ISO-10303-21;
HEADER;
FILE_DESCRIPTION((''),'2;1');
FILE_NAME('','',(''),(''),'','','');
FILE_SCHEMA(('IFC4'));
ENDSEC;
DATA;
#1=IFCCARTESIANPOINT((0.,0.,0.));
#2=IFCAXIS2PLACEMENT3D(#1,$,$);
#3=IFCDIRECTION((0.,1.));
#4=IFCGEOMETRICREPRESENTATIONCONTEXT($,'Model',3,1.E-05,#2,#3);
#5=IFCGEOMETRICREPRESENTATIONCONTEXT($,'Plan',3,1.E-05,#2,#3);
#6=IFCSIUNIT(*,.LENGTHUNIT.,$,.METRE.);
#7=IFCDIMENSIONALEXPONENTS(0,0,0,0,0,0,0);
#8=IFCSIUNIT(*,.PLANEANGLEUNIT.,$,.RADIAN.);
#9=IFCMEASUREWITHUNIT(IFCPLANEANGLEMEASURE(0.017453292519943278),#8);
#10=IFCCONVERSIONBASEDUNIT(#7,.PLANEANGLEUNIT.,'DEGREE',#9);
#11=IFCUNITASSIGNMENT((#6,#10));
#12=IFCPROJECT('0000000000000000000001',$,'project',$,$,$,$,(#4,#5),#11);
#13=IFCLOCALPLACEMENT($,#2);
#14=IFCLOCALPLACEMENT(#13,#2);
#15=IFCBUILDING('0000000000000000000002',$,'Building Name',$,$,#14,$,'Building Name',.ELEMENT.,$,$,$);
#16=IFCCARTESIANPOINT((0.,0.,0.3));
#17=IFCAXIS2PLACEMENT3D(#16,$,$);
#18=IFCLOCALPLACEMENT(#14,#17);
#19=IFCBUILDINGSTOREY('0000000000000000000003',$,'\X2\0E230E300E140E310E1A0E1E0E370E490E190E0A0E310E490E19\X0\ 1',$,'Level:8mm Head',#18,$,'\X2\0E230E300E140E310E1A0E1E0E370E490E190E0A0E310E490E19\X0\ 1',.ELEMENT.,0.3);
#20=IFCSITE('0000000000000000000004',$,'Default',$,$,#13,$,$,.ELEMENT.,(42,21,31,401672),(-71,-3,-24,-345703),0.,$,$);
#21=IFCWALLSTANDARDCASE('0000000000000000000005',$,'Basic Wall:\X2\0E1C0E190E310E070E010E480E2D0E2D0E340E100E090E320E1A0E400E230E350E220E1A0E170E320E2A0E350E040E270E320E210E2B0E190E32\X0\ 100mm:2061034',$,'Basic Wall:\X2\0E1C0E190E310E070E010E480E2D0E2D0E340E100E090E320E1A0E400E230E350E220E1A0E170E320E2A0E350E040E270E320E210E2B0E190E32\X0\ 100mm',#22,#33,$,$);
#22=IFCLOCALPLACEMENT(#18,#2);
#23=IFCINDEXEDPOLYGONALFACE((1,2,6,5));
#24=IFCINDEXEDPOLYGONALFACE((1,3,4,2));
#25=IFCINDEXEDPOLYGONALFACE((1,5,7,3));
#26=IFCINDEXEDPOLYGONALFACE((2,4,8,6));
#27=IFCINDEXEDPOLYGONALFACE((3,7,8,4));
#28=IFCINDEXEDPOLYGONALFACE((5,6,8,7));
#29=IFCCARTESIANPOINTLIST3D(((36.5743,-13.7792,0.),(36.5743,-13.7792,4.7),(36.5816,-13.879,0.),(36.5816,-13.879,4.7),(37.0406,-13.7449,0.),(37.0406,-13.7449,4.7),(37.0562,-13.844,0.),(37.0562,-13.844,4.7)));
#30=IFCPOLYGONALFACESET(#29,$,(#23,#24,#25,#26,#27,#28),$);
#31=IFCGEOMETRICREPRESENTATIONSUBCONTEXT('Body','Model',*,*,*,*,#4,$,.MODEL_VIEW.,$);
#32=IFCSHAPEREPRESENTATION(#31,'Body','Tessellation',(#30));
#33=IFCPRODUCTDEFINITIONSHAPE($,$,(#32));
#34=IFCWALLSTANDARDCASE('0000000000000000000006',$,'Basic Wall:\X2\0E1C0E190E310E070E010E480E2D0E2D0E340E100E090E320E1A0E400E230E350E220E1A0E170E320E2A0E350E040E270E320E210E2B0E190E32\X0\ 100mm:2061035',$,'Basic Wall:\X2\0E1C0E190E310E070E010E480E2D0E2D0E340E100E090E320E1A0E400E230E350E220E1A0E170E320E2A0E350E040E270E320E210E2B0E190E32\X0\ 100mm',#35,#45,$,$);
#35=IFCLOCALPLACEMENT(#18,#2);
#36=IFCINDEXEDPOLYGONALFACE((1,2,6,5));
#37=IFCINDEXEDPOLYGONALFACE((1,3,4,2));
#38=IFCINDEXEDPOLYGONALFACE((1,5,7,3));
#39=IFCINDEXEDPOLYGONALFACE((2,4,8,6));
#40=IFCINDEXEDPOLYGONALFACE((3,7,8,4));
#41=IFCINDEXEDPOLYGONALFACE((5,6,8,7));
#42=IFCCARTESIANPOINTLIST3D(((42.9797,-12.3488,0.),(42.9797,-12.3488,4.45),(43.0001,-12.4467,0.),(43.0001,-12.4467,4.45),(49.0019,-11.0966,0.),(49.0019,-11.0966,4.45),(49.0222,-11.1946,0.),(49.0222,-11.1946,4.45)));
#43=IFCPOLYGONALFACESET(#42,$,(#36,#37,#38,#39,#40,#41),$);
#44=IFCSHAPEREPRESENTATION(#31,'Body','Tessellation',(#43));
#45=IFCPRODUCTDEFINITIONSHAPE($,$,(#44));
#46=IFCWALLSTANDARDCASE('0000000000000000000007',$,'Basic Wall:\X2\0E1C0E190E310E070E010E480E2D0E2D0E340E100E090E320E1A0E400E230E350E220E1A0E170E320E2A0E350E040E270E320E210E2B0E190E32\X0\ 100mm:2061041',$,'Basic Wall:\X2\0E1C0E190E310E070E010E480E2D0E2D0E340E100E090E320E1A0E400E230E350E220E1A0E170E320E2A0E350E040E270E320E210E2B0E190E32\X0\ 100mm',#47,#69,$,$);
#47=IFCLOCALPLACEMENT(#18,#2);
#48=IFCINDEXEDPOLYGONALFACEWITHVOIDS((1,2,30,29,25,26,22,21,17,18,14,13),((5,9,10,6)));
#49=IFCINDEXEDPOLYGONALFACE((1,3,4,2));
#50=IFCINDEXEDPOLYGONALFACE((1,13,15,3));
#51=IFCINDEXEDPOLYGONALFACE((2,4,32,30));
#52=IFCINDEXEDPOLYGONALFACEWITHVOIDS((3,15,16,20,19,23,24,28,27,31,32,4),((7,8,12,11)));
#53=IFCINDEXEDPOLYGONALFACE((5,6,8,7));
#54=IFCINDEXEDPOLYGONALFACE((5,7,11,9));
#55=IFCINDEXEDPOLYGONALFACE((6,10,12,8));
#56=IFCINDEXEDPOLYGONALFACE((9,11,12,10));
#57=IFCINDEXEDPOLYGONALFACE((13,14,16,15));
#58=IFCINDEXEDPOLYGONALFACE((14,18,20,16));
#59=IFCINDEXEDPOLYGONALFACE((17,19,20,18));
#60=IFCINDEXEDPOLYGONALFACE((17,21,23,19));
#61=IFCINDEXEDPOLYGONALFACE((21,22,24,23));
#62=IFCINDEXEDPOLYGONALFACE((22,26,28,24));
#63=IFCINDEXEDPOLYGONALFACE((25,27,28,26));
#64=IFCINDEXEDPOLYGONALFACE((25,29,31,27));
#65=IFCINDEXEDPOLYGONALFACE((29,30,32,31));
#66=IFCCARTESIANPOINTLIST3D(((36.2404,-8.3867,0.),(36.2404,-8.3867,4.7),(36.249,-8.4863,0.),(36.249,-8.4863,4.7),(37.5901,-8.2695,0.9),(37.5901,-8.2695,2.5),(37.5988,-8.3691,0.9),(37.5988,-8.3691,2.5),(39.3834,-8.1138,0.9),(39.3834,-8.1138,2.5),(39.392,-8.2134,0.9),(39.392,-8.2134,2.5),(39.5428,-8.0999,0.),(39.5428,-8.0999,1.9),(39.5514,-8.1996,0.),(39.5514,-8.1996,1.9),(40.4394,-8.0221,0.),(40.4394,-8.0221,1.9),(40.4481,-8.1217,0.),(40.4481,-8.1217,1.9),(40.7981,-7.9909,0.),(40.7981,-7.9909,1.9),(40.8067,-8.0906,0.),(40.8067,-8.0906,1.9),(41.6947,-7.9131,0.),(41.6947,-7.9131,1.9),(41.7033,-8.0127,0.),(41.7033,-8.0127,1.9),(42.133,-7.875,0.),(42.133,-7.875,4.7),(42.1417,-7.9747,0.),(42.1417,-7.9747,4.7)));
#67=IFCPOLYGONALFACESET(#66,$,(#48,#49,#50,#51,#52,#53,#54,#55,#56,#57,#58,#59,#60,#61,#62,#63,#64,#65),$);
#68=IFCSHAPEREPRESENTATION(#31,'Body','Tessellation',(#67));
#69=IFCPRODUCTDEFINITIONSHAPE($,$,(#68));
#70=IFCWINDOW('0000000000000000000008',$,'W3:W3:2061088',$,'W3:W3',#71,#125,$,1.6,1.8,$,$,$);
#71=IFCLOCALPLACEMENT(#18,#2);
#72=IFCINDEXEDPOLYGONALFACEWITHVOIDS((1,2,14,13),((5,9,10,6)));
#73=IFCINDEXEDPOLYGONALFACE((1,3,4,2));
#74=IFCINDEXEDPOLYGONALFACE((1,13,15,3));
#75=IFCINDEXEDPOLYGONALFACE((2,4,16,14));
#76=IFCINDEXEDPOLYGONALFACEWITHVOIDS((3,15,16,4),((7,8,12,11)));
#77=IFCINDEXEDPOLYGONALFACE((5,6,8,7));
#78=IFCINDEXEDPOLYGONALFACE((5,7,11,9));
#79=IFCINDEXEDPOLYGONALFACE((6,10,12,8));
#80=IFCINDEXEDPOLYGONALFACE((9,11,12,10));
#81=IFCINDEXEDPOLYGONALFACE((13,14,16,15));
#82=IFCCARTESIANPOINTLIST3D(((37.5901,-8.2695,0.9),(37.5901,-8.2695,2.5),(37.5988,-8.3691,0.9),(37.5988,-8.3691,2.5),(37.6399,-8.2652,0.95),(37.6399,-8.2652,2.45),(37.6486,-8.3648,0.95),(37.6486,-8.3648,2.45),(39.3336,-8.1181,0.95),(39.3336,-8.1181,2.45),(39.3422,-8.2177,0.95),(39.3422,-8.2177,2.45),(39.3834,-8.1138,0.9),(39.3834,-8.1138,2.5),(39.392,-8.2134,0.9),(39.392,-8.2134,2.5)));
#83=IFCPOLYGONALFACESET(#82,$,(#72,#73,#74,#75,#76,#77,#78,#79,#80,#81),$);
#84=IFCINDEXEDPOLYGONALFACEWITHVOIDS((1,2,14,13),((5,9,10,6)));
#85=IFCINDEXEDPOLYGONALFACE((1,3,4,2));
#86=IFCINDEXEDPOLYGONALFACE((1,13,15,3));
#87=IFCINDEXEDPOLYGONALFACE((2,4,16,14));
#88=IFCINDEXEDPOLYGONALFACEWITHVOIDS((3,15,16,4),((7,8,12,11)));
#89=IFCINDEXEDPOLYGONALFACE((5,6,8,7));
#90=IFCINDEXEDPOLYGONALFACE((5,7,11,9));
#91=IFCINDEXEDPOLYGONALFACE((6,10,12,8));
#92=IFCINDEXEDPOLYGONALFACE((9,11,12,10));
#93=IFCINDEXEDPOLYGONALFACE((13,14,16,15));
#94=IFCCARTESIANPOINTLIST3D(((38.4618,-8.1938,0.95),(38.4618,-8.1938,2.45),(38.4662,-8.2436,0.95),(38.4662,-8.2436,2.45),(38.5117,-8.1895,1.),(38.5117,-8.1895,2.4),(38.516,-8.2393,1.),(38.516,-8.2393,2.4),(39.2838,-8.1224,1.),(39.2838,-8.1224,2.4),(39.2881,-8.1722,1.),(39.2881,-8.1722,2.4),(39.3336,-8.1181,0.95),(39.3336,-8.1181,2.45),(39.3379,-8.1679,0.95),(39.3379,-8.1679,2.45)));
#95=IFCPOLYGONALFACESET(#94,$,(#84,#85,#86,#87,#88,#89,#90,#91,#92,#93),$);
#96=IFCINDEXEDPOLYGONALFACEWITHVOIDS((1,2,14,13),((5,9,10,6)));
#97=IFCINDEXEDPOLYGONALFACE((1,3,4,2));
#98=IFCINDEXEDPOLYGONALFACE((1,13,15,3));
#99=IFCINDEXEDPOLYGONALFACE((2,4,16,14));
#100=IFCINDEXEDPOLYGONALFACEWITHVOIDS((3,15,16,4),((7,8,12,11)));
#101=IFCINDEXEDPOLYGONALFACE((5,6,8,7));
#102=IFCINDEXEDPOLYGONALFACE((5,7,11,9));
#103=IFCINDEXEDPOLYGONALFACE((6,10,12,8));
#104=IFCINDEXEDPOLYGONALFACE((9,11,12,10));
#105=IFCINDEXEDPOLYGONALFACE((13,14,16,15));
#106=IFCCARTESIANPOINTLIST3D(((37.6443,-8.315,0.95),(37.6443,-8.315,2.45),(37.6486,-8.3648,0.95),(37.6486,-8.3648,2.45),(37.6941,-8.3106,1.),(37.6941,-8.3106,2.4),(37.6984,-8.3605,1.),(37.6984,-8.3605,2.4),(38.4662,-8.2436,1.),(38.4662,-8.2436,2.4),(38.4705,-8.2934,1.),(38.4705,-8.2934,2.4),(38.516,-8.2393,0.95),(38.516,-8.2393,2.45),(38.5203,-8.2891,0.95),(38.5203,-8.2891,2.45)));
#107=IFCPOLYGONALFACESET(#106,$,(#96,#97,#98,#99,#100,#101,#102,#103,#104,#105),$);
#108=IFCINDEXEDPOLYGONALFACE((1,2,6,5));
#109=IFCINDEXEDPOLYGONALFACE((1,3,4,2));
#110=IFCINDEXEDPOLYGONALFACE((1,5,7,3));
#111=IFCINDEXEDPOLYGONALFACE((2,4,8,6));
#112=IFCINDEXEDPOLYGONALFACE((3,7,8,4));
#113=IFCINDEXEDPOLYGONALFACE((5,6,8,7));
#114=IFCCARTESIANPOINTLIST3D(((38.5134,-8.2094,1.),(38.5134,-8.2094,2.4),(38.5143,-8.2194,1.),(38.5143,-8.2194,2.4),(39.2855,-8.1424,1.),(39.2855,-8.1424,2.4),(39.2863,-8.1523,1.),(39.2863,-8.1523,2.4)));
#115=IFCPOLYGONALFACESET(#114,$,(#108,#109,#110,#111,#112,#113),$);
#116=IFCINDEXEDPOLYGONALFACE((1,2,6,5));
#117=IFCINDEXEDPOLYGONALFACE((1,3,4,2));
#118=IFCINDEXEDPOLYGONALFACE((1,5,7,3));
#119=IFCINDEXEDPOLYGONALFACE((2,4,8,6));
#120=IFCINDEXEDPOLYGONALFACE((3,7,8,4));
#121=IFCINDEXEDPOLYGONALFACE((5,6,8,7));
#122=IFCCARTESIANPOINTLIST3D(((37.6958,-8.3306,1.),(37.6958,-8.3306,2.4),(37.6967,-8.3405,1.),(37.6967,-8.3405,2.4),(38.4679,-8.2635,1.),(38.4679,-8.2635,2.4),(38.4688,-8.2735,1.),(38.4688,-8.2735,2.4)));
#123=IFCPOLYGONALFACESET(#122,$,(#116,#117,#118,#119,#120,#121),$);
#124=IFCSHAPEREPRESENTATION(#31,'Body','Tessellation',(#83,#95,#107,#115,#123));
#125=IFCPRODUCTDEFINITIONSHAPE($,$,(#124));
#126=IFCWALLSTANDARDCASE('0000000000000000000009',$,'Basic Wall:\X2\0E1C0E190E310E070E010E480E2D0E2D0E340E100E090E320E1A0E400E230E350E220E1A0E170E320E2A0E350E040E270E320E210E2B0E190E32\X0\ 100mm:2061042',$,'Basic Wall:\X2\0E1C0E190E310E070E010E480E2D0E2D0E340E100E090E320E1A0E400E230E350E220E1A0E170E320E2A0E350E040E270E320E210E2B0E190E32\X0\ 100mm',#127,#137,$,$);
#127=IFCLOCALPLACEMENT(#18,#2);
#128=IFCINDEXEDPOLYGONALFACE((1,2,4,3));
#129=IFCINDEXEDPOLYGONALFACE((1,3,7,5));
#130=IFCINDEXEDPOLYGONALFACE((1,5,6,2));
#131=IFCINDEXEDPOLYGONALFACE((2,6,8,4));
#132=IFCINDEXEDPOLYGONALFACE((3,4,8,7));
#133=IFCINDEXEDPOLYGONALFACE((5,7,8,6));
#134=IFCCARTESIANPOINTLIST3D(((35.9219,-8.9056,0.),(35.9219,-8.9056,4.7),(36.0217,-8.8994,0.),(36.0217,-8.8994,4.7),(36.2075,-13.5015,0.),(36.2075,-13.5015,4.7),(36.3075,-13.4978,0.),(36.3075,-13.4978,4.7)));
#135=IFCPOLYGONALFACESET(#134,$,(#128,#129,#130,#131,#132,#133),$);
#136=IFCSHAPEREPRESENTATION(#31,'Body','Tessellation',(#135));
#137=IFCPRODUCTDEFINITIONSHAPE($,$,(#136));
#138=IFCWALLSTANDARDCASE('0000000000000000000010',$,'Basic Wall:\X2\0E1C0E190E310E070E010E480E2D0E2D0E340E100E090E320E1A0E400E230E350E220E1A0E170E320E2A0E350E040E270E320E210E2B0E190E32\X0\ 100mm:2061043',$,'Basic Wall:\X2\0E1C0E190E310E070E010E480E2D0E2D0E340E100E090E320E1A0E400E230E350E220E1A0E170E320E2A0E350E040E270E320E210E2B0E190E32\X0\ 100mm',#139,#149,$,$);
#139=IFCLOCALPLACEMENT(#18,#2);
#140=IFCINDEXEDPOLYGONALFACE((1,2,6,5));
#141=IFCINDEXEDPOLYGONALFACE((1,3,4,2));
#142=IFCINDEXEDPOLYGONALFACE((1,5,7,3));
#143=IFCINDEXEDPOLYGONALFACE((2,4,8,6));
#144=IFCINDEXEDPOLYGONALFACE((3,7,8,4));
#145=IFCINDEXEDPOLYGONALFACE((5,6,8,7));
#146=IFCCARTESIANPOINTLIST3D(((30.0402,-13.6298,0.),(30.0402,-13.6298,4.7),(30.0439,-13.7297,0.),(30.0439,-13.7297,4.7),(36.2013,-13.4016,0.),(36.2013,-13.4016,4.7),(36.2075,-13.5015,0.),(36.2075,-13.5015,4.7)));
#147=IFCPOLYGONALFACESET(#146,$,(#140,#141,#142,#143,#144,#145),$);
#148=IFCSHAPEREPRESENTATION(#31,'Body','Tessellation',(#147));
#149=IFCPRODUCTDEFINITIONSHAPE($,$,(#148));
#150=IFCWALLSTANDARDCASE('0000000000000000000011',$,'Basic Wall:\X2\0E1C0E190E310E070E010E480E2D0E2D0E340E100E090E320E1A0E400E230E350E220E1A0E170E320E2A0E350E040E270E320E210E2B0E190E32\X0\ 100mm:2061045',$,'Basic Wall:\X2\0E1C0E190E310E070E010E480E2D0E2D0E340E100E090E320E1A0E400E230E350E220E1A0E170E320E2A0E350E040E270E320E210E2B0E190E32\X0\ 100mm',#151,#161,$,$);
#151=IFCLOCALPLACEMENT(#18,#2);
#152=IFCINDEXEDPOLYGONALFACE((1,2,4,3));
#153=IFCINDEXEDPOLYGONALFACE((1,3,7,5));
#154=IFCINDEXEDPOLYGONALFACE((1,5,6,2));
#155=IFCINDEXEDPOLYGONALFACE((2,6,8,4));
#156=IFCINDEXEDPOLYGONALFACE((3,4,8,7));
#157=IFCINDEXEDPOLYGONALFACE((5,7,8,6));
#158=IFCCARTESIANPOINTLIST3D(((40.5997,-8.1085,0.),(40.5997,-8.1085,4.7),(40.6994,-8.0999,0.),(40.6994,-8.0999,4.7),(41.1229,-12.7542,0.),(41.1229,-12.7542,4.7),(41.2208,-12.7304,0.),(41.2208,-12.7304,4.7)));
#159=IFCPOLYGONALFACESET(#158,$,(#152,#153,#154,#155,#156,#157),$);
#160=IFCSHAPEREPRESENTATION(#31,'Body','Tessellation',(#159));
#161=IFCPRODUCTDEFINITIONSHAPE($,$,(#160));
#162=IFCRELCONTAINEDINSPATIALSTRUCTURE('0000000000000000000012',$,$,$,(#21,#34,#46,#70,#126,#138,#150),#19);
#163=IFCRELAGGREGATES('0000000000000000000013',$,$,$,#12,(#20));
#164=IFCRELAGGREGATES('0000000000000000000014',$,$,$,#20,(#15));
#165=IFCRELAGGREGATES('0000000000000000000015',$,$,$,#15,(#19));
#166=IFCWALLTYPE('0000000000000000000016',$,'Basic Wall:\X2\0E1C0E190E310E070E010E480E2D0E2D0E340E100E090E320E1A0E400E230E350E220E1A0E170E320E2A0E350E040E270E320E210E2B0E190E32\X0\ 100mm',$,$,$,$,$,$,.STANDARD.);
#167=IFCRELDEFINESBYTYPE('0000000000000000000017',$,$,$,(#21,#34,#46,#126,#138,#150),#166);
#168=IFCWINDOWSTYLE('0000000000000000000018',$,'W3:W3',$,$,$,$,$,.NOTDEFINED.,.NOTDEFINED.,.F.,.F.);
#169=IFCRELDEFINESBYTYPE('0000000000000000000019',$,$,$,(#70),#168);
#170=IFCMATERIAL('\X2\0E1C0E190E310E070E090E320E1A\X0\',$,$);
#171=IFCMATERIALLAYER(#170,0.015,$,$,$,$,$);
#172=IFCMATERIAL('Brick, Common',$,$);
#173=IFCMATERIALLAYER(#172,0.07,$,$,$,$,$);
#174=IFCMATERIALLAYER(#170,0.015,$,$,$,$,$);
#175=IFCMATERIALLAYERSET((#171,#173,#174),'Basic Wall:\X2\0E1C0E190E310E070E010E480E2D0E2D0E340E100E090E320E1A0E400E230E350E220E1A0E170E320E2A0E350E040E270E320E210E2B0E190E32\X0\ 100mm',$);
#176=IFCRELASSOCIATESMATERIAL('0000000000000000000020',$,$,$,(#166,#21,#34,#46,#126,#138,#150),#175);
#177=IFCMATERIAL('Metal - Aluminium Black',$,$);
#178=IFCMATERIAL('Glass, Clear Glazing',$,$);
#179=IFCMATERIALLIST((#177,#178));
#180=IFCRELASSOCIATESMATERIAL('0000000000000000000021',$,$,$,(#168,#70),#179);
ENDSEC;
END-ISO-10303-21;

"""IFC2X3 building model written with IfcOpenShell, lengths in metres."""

from ifc_helpers import new_model, entity, si_unit, converted_unit, direction, frame, frame_2d, origin, place, context, subcontext, project, spatial, polyline, rectangle, outline, extrude, clip, halfspace, source, transform, mapped, material, material_list, layer, layer_set, layer_usage, type_object, type_shapes, element, fill, save


model = new_model("IFC2X3")

# Units and contexts
model_context = context("Model", 3, precision=1e-05, world=origin(), true_north=direction((0.0, 1.0)))
plan_context = context("Plan", 3, precision=1e-05, world=origin(), true_north=direction((0.0, 1.0)))
body_context = subcontext(model_context, "Body", "Model", "MODEL_VIEW")
ifc_project = project(units=[si_unit("LENGTHUNIT", "METRE"), converted_unit("PLANEANGLEUNIT", "DEGREE", entity("IfcPlaneAngleMeasure", 0.017453292519943278), si_unit("PLANEANGLEUNIT", "RADIAN"), dimensions=[0, 0, 0, 0, 0, 0, 0])], contexts=[model_context, plan_context])

# Site, building, storey
site_placement = place(None, origin())
site = spatial("IfcSite", under=ifc_project, at=site_placement, Name="Default", CompositionType="ELEMENT", RefLatitude=(42, 21, 31, 401672), RefLongitude=(-71, -3, -24, -345703), RefElevation=0.0)
building_placement = place(site_placement, origin())
building = spatial("IfcBuilding", under=site, at=building_placement, Name="Building Name", LongName="Building Name", CompositionType="ELEMENT")
storey_placement = place(building_placement, frame((0.0, 0.0, 0.3)))
storey = spatial("IfcBuildingStorey", under=building, at=storey_placement, Name="ระดับพื้นชั้น 1", ObjectType="Level:8mm Head", LongName="ระดับพื้นชั้น 1", CompositionType="ELEMENT", Elevation=0.3)

# Shared definitions
ifc_material_1 = material(Name="Glass, Clear Glazing")

# Shared definitions
ifc_material_2 = material(Name="ผนังฉาบ")
ifc_layer_1 = layer(ifc_material_2, 0.015)
ifc_material_3 = material(Name="Brick, Common")
ifc_layer_2 = layer(ifc_material_3, 0.07)
ifc_layer_3 = layer(ifc_material_2, 0.015)
ifc_layer_set = layer_set([ifc_layer_1, ifc_layer_2, ifc_layer_3], Name="Basic Wall:ผนังก่ออิฐฉาบเรียบทาสีความหนา 100mm")
wall_type = type_object("IfcWallType", Name="Basic Wall:ผนังก่ออิฐฉาบเรียบทาสีความหนา 100mm", PredefinedType="STANDARD", material=ifc_layer_set)

# Shared definitions
ifc_material_4 = material(Name="Metal - Aluminium Black")
ifc_material_list_1 = material_list([ifc_material_4, ifc_material_1])
window_style = type_object("IfcWindowStyle", Name="W3:W3", ConstructionType="NOTDEFINED", OperationType="NOTDEFINED", ParameterTakesPrecedence=False, Sizeable=False, material=ifc_material_list_1)
shared_shape_1 = source(origin(), body_context, "Body", "SweptSolid", [
    extrude(outline(polyline([(-0.8, -0.9), (0.8, -0.9), (0.8, 0.9), (-0.8, 0.9), (-0.8, -0.9)]), holes=[polyline([(0.75, -0.85), (-0.75, -0.85), (-0.75, 0.85), (0.75, 0.85), (0.75, -0.85)])]), frame((0.9, 0.0, 0.8), z_axis=(0.0, 1.0, 0.0), x_axis=(0.0, 0.0, 1.0)), (0.0, 0.0, 1.0), 0.1),
    extrude(outline(polyline([(-0.75, -0.4375), (0.75, -0.4375), (0.75, 0.4375), (-0.75, 0.4375), (-0.75, -0.4375)]), holes=[polyline([(0.7, -0.3875), (-0.7, -0.3875), (-0.7, 0.3875), (0.7, 0.3875), (0.7, -0.3875)])]), frame((1.3125, 0.05, 0.8), z_axis=(0.0, 1.0, 0.0), x_axis=(0.0, 0.0, -1.0)), (0.0, 0.0, 1.0), 0.05),
    extrude(outline(polyline([(-0.75, -0.4375), (0.75, -0.4375), (0.75, 0.4375), (-0.75, 0.4375), (-0.75, -0.4375)]), holes=[polyline([(0.7, -0.3875), (-0.7, -0.3875), (-0.7, 0.3875), (0.7, 0.3875), (0.7, -0.3875)])]), frame((0.4875, 0.0, 0.8), z_axis=(0.0, 1.0, 0.0), x_axis=(0.0, 0.0, -1.0)), (0.0, 0.0, 1.0), 0.05),
    extrude(rectangle(XDim=0.01, YDim=0.775, at=frame_2d((0.0, 0.0), x_axis=(1.0, 0.0))), frame((1.3125, 0.075, 0.1), z_axis=(0.0, 0.0, 1.0), x_axis=(0.0, -1.0, 0.0)), (0.0, 0.0, 1.0), 1.4),
    extrude(rectangle(XDim=0.01, YDim=0.775, at=frame_2d((0.0, 0.0), x_axis=(1.0, 0.0))), frame((0.4875, 0.025, 0.1), z_axis=(0.0, 0.0, 1.0), x_axis=(0.0, -1.0, 0.0)), (0.0, 0.0, 1.0), 1.4),
])
type_shapes(window_style, [shared_shape_1])

# Walls
ifc_layer_usage_1 = layer_usage(ifc_layer_set, "AXIS2", "POSITIVE", -0.05)
wall_1_placement = place(storey_placement, frame((36.578, -13.8291, 0.0), z_axis=(0.0, 0.0, 1.0), x_axis=(0.997301, 0.073417, 0.0)))
element("IfcWallStandardCase", 1, at=wall_1_placement, inside=storey, type_object=wall_type, material=ifc_layer_usage_1, Name="Basic Wall:ผนังก่ออิฐฉาบเรียบทาสีความหนา 100mm:2061034", ObjectType="Basic Wall:ผนังก่ออิฐฉาบเรียบทาสีความหนา 100mm", context=body_context, shape_type="Clipping", body=[
    clip(extrude(outline(polyline([(0.4759, -0.05), (0.4676, 0.05), (0.0, 0.05), (0.0, -0.05), (0.3646, -0.05), (0.4759, -0.05)])), origin(), (0.0, 0.0, 1.0), 4.7), halfspace(frame((0.0, 0.0, -0.15)), True)),
])
ifc_layer_usage_2 = layer_usage(ifc_layer_set, "AXIS2", "POSITIVE", -0.05)
wall_2_placement = place(storey_placement, frame((42.9899, -12.3978, 0.0), z_axis=(0.0, 0.0, 1.0), x_axis=(0.97906, 0.203573, 0.0)))
element("IfcWallStandardCase", 2, at=wall_2_placement, inside=storey, type_object=wall_type, material=ifc_layer_usage_2, Name="Basic Wall:ผนังก่ออิฐฉาบเรียบทาสีความหนา 100mm:2061035", ObjectType="Basic Wall:ผนังก่ออิฐฉาบเรียบทาสีความหนา 100mm", context=body_context, shape_type="Clipping", body=[
    clip(extrude(rectangle(XDim=6.151, YDim=0.1, at=frame_2d((3.0755, 0.0), x_axis=(-1.0, 0.0))), origin(), (0.0, 0.0, 1.0), 4.45), halfspace(frame((0.0, 0.0, -0.15)), True)),
])

# Wall, openings, window
ifc_layer_usage_3 = layer_usage(ifc_layer_set, "AXIS2", "POSITIVE", -0.05)
wall_3_placement = place(storey_placement, frame((42.1374, -7.9248, 0.0), z_axis=(0.0, 0.0, 1.0), x_axis=(-0.996252, -0.086502, 0.0)))
wall_3 = element("IfcWallStandardCase", 3, at=wall_3_placement, inside=storey, type_object=wall_type, material=ifc_layer_usage_3, Name="Basic Wall:ผนังก่ออิฐฉาบเรียบทาสีความหนา 100mm:2061041", ObjectType="Basic Wall:ผนังก่ออิฐฉาบเรียบทาสีความหนา 100mm", context=body_context, shape_type="Clipping", body=[
    clip(extrude(rectangle(XDim=5.9148, YDim=0.1, at=frame_2d((2.9574, 0.0), x_axis=(1.0, 0.0))), origin(), (0.0, 0.0, 1.0), 4.7), halfspace(frame((0.0, 0.0, -0.15)), True)),
])
opening_1_placement = place(wall_3_placement, frame((41.2939, -11.5401, -0.15), z_axis=(0.0, 0.0, 1.0), x_axis=(-0.996252, 0.086502, 0.0)))
element("IfcOpeningElement", 4, at=opening_1_placement, cuts=wall_3, ObjectType="Opening", context=body_context, shape_type="SweptSolid", body=[
    extrude(rectangle(XDim=2.05, YDim=0.9, at=frame_2d((0.0, 0.0), x_axis=(1.0, 0.0))), frame((41.1145, -6.4337, 1.025), z_axis=(0.086502, -0.996252, 0.0), x_axis=(0.0, 0.0, 1.0)), (0.0, 0.0, 1.0), 3.048),
])
opening_2_placement = place(wall_3_placement, frame((41.2939, -11.5401, -0.15), z_axis=(0.0, 0.0, 1.0), x_axis=(-0.996252, 0.086502, 0.0)))
element("IfcOpeningElement", 5, at=opening_2_placement, cuts=wall_3, ObjectType="Opening", context=body_context, shape_type="SweptSolid", body=[
    extrude(rectangle(XDim=2.05, YDim=0.9, at=frame_2d((0.0, 0.0), x_axis=(0.0, 1.0))), frame((39.8593, -6.5427, 1.025), z_axis=(0.086502, -0.996252, 0.0), x_axis=(0.996252, 0.086502, 0.0)), (0.0, 0.0, 1.0), 3.048),
])
opening_3_placement = place(wall_3_placement, frame((4.56, 0.05, 0.9)))
opening_3 = element("IfcOpeningElement", 6, at=opening_3_placement, cuts=wall_3, ObjectType="Opening", context=body_context, shape_type="SweptSolid", body=[
    extrude(rectangle(XDim=1.6, YDim=1.8, at=frame_2d((0.8, 0.9), x_axis=(1.0, 0.0))), frame((0.0, 0.0, 0.0), z_axis=(0.0, -1.0, 0.0), x_axis=(0.0, 0.0, 1.0)), (0.0, 0.0, 1.0), 0.1),
])
window_1_placement = place(opening_3_placement, frame((0.0, 0.0, 0.0), z_axis=(0.0, 0.0, 1.0), x_axis=(-1.0, 0.0, 0.0)))
window_1 = element("IfcWindow", 7, at=window_1_placement, inside=storey, type_object=window_style, material=ifc_material_list_1, Name="W3:W3:2061088", ObjectType="W3:W3", OverallHeight=1.6, OverallWidth=1.8, context=body_context, shape_type="MappedRepresentation", body=[
    mapped(shared_shape_1, transform((0.0, 0.0, 0.0), scale=1.0)),
])
fill(opening_3, window_1)

# Walls
ifc_layer_usage_4 = layer_usage(ifc_layer_set, "AXIS2", "POSITIVE", -0.05)
wall_4_placement = place(storey_placement, frame((35.9718, -8.9025, 0.0), z_axis=(0.0, 0.0, 1.0), x_axis=(0.062014, -0.998075, 0.0)))
element("IfcWallStandardCase", 8, at=wall_4_placement, inside=storey, type_object=wall_type, material=ifc_layer_usage_4, Name="Basic Wall:ผนังก่ออิฐฉาบเรียบทาสีความหนา 100mm:2061042", ObjectType="Basic Wall:ผนังก่ออิฐฉาบเรียบทาสีความหนา 100mm", context=body_context, shape_type="Clipping", body=[
    clip(extrude(outline(polyline([(4.6047, -0.05), (4.6072, 0.05), (0.0, 0.05), (0.0, -0.05), (4.5047, -0.05), (4.6047, -0.05)])), origin(), (0.0, 0.0, 1.0), 4.7), halfspace(frame((0.0, 0.0, -0.15)), True)),
])
ifc_layer_usage_5 = layer_usage(ifc_layer_set, "AXIS2", "POSITIVE", -0.05)
wall_5_placement = place(storey_placement, frame((36.2056, -13.4515, 0.0), z_axis=(0.0, 0.0, 1.0), x_axis=(-0.999315, -0.037003, 0.0)))
element("IfcWallStandardCase", 9, at=wall_5_placement, inside=storey, type_object=wall_type, material=ifc_layer_usage_5, Name="Basic Wall:ผนังก่ออิฐฉาบเรียบทาสีความหนา 100mm:2061043", ObjectType="Basic Wall:ผนังก่ออิฐฉาบเรียบทาสีความหนา 100mm", context=body_context, shape_type="Clipping", body=[
    clip(extrude(outline(polyline([(6.1678, -0.05), (6.1678, 0.05), (0.0, 0.05), (0.0025, -0.05), (6.1678, -0.05)])), origin(), (0.0, 0.0, 1.0), 4.7), halfspace(frame((0.0, 0.0, -0.15)), True)),
])
ifc_layer_usage_6 = layer_usage(ifc_layer_set, "AXIS2", "POSITIVE", -0.05)
wall_6_placement = place(storey_placement, frame((40.6494, -8.1029, 0.0), z_axis=(0.0, 0.0, 1.0), x_axis=(0.111904, -0.993719, 0.0)))
element("IfcWallStandardCase", 10, at=wall_6_placement, inside=storey, type_object=wall_type, material=ifc_layer_usage_6, Name="Basic Wall:ผนังก่ออิฐฉาบเรียบทาสีความหนา 100mm:2061045", ObjectType="Basic Wall:ผนังก่ออิฐฉาบเรียบทาสีความหนา 100mm", context=body_context, shape_type="Clipping", body=[
    clip(extrude(outline(polyline([(4.675, -0.05), (4.6623, 0.05), (2.4509, 0.05), (2.3509, 0.05), (0.0026, 0.05), (0.0, -0.05), (4.675, -0.05)])), origin(), (0.0, 0.0, 1.0), 4.7), halfspace(frame((0.0, 0.0, -0.15)), True)),
])

save(model, "model.ifc")
